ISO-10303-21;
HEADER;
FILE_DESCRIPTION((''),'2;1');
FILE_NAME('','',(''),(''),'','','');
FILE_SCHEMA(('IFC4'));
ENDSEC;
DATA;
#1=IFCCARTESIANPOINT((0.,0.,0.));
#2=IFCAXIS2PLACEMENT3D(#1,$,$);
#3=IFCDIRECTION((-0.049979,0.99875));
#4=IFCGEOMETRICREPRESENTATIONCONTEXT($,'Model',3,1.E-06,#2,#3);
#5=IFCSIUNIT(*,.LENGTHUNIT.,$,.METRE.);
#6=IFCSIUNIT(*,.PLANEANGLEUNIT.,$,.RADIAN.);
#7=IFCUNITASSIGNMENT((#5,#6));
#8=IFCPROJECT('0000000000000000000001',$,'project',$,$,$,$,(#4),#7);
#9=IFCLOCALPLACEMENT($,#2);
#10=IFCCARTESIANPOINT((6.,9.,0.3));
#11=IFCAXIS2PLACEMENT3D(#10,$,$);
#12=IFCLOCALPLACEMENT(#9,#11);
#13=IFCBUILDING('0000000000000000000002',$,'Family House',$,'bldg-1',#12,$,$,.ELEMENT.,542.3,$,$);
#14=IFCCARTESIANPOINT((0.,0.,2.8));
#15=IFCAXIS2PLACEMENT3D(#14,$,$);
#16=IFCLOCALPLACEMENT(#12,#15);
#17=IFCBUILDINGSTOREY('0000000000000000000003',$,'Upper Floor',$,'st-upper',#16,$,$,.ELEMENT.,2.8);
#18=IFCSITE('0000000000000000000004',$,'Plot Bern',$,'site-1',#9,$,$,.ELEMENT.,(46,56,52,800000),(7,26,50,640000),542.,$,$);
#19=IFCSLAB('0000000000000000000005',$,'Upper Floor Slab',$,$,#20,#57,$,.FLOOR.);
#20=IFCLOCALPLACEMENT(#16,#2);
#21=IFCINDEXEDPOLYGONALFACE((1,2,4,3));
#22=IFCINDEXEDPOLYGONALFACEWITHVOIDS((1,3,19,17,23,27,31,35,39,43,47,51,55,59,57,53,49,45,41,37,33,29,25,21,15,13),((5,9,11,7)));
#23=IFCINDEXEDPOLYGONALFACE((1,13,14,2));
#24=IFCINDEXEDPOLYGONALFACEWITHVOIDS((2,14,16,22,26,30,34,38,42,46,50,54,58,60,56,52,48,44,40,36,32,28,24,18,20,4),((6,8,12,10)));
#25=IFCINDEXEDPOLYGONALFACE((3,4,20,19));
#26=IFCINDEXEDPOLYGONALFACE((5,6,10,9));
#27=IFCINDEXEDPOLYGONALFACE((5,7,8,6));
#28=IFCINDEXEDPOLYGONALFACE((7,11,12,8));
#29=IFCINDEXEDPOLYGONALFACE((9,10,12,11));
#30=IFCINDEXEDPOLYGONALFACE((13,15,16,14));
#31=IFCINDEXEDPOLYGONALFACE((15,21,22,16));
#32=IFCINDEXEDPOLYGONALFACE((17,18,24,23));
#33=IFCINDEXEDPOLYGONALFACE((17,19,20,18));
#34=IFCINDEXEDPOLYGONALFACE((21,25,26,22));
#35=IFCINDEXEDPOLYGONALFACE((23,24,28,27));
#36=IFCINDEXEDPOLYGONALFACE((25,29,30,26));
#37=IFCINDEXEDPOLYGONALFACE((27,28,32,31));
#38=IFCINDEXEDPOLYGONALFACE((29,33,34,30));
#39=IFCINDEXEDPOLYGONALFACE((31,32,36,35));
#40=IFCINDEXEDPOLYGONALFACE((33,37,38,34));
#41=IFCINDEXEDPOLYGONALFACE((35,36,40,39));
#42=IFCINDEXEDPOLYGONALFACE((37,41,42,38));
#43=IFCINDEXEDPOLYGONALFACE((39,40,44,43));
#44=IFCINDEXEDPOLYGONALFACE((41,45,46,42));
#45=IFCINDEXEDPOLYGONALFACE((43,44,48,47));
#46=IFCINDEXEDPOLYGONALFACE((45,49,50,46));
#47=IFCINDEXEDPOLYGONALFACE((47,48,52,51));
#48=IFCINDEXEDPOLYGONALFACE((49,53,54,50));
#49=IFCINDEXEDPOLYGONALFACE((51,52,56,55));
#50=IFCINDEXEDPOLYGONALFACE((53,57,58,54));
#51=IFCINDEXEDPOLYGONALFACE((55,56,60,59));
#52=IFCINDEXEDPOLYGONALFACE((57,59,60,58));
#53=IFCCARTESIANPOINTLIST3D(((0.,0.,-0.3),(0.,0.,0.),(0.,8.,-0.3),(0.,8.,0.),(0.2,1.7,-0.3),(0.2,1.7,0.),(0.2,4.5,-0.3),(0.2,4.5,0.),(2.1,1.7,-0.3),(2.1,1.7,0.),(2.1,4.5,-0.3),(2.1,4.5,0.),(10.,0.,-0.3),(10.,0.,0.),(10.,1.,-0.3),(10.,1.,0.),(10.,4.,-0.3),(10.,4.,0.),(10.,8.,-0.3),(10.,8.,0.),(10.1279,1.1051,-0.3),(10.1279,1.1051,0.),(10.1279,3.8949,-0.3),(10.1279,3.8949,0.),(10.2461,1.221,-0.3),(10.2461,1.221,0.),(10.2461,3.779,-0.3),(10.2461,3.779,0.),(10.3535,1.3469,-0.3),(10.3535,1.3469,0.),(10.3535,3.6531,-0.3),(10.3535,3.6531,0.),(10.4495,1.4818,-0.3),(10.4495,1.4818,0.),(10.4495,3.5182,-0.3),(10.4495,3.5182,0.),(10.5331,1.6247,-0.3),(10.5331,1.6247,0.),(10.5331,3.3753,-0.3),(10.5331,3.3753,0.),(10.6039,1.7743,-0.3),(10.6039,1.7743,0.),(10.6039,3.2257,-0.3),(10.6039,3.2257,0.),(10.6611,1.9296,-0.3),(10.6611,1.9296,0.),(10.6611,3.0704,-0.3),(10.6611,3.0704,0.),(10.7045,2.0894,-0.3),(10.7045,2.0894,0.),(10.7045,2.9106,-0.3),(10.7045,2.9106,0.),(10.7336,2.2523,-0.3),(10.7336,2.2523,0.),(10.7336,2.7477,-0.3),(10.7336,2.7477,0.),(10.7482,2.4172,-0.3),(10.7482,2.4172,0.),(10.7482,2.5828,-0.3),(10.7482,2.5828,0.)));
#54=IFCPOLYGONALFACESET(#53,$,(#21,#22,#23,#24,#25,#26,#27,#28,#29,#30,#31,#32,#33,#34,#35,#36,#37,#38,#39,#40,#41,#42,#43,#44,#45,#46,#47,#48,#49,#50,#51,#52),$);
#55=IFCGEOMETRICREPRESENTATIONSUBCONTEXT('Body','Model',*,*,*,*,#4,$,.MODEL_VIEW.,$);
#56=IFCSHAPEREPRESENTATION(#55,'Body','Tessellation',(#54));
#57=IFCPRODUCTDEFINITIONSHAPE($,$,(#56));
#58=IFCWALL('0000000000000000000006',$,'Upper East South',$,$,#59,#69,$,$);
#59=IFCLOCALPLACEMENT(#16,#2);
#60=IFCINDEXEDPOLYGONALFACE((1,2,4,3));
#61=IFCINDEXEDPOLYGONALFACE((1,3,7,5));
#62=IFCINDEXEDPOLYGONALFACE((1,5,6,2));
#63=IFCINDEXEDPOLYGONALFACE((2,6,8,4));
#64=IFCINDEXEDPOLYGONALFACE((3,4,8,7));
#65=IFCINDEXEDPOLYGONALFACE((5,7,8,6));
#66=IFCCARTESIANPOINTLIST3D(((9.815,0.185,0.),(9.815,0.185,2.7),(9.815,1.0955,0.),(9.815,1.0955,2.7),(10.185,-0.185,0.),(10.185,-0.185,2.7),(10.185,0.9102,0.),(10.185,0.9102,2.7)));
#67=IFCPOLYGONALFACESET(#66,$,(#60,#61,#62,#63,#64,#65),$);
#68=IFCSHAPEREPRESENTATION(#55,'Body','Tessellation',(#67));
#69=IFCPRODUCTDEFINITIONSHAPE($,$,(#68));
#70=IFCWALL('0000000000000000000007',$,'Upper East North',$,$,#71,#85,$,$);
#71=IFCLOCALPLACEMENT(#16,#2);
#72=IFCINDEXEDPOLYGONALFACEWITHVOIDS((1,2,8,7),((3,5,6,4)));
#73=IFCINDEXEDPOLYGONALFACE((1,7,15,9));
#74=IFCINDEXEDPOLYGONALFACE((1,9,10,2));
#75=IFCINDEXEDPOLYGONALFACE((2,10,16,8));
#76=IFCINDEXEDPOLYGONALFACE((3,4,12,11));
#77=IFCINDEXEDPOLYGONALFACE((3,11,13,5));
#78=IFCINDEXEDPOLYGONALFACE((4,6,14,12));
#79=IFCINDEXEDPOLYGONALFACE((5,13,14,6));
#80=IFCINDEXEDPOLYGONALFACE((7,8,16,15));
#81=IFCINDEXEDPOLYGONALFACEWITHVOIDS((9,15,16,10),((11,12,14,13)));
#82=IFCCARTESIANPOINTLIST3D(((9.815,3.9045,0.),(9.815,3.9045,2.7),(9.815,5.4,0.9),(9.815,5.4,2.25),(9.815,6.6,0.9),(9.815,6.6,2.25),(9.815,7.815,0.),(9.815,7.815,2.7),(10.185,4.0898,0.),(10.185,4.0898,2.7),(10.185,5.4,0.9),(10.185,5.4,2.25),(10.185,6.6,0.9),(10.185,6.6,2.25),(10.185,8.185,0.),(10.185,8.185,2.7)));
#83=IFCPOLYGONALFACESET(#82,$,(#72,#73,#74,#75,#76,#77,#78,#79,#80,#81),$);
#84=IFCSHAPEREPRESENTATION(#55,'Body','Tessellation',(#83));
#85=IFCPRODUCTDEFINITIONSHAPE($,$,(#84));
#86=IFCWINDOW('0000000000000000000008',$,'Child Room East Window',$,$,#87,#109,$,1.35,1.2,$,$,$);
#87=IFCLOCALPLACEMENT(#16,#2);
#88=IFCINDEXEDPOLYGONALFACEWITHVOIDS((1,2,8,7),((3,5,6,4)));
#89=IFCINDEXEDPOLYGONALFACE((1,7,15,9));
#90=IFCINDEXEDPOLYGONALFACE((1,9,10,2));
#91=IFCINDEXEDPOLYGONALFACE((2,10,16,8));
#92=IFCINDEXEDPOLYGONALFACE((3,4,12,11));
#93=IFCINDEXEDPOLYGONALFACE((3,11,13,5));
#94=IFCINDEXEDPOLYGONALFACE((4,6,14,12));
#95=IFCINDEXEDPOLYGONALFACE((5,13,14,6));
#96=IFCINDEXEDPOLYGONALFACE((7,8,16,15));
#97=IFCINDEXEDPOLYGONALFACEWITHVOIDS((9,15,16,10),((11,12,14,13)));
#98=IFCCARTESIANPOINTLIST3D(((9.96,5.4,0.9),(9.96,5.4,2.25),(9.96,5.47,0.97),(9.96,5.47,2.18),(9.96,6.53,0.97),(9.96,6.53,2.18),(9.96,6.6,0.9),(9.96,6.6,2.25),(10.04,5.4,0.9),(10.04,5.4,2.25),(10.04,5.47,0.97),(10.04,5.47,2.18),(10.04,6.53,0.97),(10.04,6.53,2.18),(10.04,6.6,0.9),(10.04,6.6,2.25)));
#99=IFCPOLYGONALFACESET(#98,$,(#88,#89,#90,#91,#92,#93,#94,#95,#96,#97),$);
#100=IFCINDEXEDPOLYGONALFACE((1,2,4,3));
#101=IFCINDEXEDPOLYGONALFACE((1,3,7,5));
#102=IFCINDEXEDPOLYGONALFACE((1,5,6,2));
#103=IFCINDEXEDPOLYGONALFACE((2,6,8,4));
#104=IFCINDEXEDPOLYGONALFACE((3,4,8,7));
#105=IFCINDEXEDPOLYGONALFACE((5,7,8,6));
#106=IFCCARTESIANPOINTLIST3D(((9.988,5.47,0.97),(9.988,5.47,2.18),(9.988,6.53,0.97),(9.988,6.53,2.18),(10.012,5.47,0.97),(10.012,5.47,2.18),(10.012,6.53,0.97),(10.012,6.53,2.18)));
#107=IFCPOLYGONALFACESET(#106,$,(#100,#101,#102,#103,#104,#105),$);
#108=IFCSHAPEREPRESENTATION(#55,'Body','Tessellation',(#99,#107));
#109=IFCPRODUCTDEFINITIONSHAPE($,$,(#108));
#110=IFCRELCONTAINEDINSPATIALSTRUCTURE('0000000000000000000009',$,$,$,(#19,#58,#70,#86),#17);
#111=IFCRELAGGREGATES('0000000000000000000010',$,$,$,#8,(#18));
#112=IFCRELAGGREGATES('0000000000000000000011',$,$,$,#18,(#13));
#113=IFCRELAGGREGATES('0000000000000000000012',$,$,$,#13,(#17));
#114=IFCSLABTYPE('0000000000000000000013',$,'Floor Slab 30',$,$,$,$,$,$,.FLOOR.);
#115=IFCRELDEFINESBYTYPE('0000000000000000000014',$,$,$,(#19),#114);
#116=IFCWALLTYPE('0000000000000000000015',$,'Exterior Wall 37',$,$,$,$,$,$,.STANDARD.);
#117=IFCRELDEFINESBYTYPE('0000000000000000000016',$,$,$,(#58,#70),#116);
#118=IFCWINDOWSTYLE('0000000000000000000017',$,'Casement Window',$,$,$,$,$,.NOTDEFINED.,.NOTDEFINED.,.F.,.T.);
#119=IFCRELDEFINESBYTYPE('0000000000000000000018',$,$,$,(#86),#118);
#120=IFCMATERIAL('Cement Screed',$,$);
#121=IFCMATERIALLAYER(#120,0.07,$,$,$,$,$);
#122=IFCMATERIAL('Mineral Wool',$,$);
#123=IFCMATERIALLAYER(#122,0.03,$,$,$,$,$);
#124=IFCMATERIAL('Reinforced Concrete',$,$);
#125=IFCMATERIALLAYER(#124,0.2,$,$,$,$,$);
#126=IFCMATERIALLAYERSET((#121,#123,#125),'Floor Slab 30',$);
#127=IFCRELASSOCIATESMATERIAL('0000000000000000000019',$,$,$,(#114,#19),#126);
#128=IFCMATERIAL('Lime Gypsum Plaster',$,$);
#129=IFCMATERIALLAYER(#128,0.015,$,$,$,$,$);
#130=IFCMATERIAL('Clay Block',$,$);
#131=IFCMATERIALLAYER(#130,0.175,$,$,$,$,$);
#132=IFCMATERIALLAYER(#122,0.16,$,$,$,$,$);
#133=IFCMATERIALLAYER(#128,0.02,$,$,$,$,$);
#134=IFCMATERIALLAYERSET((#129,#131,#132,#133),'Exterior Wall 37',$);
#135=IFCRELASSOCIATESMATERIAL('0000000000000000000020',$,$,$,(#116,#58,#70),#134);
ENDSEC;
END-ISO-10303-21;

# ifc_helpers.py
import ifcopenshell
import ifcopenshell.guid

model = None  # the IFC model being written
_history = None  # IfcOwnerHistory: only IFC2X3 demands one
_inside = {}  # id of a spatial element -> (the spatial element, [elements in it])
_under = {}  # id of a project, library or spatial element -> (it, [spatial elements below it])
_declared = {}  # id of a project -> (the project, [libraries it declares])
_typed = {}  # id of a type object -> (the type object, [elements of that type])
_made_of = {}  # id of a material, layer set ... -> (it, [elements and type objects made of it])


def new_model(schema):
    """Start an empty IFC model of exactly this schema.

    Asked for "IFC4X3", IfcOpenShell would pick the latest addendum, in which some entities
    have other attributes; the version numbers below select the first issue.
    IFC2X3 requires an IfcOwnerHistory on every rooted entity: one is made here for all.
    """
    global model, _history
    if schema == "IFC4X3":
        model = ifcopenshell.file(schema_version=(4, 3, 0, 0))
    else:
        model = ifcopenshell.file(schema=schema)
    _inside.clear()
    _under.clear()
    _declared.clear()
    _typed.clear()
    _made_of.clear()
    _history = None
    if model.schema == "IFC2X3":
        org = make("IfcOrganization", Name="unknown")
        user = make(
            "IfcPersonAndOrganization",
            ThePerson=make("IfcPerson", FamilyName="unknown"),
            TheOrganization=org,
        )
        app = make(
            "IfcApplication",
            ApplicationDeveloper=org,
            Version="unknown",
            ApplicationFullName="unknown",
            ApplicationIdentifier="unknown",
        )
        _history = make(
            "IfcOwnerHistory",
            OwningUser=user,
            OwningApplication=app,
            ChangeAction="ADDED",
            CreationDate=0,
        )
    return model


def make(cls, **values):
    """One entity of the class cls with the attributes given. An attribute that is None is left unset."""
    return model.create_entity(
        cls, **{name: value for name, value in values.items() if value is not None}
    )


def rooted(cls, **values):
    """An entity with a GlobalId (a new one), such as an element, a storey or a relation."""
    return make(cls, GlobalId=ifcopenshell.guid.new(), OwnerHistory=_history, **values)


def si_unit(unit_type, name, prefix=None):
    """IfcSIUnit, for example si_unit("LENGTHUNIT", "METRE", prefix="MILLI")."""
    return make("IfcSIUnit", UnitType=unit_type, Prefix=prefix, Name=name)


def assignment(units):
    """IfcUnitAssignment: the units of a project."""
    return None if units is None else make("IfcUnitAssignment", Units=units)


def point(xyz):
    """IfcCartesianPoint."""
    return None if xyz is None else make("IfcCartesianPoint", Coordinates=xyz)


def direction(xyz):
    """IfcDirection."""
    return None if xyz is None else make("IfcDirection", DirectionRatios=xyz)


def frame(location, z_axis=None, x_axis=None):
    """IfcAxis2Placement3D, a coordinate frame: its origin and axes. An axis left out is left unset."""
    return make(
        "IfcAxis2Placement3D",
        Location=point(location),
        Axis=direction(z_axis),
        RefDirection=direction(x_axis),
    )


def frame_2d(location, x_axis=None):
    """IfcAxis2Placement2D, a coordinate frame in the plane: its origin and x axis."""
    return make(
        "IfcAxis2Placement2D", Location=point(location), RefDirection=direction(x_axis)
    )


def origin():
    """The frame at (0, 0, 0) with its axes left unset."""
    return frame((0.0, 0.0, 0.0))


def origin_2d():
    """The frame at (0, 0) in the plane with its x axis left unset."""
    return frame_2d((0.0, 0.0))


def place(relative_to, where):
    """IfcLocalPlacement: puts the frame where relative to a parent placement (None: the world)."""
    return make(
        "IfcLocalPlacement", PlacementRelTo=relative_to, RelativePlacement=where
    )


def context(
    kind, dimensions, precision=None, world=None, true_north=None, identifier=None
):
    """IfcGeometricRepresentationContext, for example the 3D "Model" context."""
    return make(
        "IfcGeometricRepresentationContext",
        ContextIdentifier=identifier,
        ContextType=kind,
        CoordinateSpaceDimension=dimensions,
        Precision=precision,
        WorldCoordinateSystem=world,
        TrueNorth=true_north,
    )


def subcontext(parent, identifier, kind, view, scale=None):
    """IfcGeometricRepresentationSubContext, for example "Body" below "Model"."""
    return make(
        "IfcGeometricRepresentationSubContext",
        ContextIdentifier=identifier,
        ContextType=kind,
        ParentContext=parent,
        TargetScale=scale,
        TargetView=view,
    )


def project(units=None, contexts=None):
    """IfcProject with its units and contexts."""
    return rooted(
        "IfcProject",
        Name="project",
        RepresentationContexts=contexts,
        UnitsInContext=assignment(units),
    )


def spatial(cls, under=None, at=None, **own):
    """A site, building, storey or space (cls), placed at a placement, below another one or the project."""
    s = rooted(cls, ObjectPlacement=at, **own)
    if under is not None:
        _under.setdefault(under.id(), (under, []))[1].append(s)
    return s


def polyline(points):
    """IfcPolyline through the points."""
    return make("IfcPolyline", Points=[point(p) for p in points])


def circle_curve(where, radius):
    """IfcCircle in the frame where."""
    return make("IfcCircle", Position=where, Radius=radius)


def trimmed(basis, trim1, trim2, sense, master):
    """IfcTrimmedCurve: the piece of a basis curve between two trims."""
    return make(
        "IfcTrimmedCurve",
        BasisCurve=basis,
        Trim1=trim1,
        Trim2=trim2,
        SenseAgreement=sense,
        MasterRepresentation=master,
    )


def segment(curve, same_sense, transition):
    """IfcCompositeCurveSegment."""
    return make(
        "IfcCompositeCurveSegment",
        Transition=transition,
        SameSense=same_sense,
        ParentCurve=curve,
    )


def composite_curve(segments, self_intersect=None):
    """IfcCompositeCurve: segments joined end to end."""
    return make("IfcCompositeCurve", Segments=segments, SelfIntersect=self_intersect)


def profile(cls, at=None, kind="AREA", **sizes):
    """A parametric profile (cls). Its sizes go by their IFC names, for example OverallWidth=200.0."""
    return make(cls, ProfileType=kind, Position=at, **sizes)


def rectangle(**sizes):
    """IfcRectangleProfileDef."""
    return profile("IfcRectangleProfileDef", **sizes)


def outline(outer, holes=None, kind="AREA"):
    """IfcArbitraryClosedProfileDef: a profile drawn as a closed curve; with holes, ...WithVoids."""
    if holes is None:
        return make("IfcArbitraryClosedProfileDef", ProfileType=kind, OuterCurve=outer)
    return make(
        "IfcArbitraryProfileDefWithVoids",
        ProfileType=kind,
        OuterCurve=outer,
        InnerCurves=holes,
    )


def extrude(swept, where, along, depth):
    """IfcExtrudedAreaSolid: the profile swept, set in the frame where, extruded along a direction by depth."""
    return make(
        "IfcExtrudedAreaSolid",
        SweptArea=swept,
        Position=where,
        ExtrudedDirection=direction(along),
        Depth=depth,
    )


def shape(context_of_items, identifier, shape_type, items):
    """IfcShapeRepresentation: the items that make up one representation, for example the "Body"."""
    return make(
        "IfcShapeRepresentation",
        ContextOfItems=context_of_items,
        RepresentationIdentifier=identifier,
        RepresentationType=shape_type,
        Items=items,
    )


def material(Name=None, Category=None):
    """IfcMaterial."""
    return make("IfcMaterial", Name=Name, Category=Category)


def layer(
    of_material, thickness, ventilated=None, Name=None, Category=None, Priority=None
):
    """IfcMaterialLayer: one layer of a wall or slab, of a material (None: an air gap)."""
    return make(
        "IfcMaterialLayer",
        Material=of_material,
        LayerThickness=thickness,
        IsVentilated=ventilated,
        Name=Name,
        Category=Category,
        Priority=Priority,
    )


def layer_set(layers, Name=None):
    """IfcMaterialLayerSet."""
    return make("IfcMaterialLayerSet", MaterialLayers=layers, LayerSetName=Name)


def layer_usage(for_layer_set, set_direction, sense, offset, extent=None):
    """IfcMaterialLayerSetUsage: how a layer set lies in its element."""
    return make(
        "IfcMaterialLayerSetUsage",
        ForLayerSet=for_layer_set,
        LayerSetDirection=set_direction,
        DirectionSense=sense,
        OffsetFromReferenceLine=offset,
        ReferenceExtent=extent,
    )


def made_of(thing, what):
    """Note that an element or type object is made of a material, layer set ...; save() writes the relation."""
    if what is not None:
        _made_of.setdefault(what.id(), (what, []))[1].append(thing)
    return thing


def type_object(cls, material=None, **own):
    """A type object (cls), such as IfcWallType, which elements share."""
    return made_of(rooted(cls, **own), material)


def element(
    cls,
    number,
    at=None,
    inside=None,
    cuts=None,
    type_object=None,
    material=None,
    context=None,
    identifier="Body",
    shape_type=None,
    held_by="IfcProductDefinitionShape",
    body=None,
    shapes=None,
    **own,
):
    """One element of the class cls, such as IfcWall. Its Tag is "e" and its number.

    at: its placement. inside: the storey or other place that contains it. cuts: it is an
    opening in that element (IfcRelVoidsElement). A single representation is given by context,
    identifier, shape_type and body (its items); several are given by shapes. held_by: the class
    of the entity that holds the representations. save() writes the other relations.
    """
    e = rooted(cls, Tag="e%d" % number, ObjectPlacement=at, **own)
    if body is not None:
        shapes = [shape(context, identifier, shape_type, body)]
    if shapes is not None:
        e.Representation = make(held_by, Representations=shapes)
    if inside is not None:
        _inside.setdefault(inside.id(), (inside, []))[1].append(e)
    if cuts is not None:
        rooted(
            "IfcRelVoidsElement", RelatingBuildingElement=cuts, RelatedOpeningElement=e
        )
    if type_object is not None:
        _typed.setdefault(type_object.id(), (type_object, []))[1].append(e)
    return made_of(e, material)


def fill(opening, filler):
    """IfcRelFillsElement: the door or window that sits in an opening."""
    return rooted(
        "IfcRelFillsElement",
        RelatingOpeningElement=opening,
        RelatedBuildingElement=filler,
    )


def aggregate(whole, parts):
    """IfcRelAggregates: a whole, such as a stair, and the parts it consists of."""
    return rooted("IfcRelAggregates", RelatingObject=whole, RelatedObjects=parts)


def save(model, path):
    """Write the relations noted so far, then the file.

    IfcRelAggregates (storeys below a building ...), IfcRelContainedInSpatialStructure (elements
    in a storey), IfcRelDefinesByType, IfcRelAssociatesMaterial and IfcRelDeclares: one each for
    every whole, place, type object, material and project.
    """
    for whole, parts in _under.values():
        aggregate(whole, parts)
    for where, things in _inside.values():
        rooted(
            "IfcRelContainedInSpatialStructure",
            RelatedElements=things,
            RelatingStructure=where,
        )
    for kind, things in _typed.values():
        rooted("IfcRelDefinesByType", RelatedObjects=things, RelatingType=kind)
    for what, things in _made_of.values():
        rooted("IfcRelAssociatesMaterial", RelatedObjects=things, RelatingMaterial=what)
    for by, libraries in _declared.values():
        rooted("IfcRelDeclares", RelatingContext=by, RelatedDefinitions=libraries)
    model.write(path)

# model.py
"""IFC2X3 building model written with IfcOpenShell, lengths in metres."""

from ifc_helpers import new_model, si_unit, point, direction, frame, frame_2d, origin, origin_2d, place, context, subcontext, project, spatial, polyline, circle_curve, trimmed, segment, composite_curve, rectangle, outline, extrude, material, layer, layer_set, layer_usage, type_object, element, fill, save


model = new_model("IFC2X3")

# Units and contexts
model_context = context("Model", 3, precision=1e-06, world=origin(), true_north=direction((-0.049979, 0.99875)))
body_context = subcontext(model_context, "Body", "Model", "MODEL_VIEW")
ifc_project = project(units=[si_unit("LENGTHUNIT", "METRE"), si_unit("PLANEANGLEUNIT", "RADIAN")], contexts=[model_context])

# Site, building, storey
site_placement = place(None, origin())
site = spatial("IfcSite", under=ifc_project, at=site_placement, Name="Plot Bern", ObjectType="site-1", CompositionType="ELEMENT", RefLatitude=(46, 56, 52, 800000), RefLongitude=(7, 26, 50, 640000), RefElevation=542.0)
building_placement = place(site_placement, frame((6.0, 9.0, 0.3)))
building = spatial("IfcBuilding", under=site, at=building_placement, Name="Family House", ObjectType="bldg-1", CompositionType="ELEMENT", ElevationOfRefHeight=542.3)
storey_placement = place(building_placement, frame((0.0, 0.0, 2.8)))
storey = spatial("IfcBuildingStorey", under=building, at=storey_placement, Name="Upper Floor", ObjectType="st-upper", CompositionType="ELEMENT", Elevation=2.8)

# Slab
ifc_material_1 = material(Name="Cement Screed")
ifc_layer_1 = layer(ifc_material_1, 0.07)
ifc_material_2 = material(Name="Mineral Wool")
ifc_layer_2 = layer(ifc_material_2, 0.03)
ifc_material_3 = material(Name="Reinforced Concrete")
ifc_layer_3 = layer(ifc_material_3, 0.2)
ifc_layer_set_1 = layer_set([ifc_layer_1, ifc_layer_2, ifc_layer_3], Name="Floor Slab 30")
ifc_layer_usage_1 = layer_usage(ifc_layer_set_1, "AXIS3", "NEGATIVE", 0.3)
slab_type = type_object("IfcSlabType", Name="Floor Slab 30", PredefinedType="FLOOR", material=ifc_layer_set_1)
slab_placement = place(storey_placement, frame((0.0, 0.0, -0.3)))
element("IfcSlab", 1, at=slab_placement, inside=storey, type_object=slab_type, material=ifc_layer_usage_1, Name="Upper Floor Slab", PredefinedType="FLOOR", context=body_context, shape_type="SweptSolid", body=[
    extrude(outline(composite_curve([segment(polyline([(0.0, 0.0), (10.0, 0.0)]), True, "CONTINUOUS"), segment(polyline([(10.0, 0.0), (10.0, 1.0)]), True, "CONTINUOUS"), segment(trimmed(circle_curve(frame_2d((8.875, 2.5)), 1.875), [point((10.0, 1.0))], [point((10.0, 4.0))], True, "CARTESIAN"), True, "CONTINUOUS"), segment(polyline([(10.0, 4.0), (10.0, 8.0)]), True, "CONTINUOUS"), segment(polyline([(10.0, 8.0), (0.0, 8.0)]), True, "CONTINUOUS"), segment(polyline([(0.0, 8.0), (0.0, 0.0)]), True, "CONTINUOUS")], self_intersect=False), holes=[polyline([(0.2, 1.7), (0.2, 4.5), (2.1, 4.5), (2.1, 1.7), (0.2, 1.7)])]), origin(), (0.0, 0.0, 1.0), 0.3),
])

# Shared definitions
ifc_material_4 = material(Name="Lime Gypsum Plaster")
ifc_layer_4 = layer(ifc_material_4, 0.015)
ifc_material_5 = material(Name="Clay Block")
ifc_layer_5 = layer(ifc_material_5, 0.175)
ifc_layer_6 = layer(ifc_material_2, 0.16)
ifc_layer_7 = layer(ifc_material_4, 0.02)
ifc_layer_set_2 = layer_set([ifc_layer_4, ifc_layer_5, ifc_layer_6, ifc_layer_7], Name="Exterior Wall 37")
wall_type_1 = type_object("IfcWallType", Name="Exterior Wall 37", PredefinedType="STANDARD", material=ifc_layer_set_2)

# Wall
ifc_layer_usage_2 = layer_usage(ifc_layer_set_2, "AXIS2", "NEGATIVE", 0.185)
wall_1_placement = place(storey_placement, origin())
element("IfcWall", 2, at=wall_1_placement, inside=storey, type_object=wall_type_1, material=ifc_layer_usage_2, Name="Upper East South", context=body_context, shape_type="SweptSolid", body=[
    extrude(outline(polyline([(10.185, -0.185), (10.185, 0.9102), (9.815, 1.0955), (9.815, 0.185), (10.185, -0.185)])), origin(), (0.0, 0.0, 1.0), 2.7),
])

# Wall, opening, window
ifc_layer_usage_3 = layer_usage(ifc_layer_set_2, "AXIS2", "NEGATIVE", 0.185)
wall_2_placement = place(storey_placement, origin())
wall_2 = element("IfcWall", 3, at=wall_2_placement, inside=storey, type_object=wall_type_1, material=ifc_layer_usage_3, Name="Upper East North", context=body_context, shape_type="SweptSolid", body=[
    extrude(outline(polyline([(10.185, 4.0898), (10.185, 8.185), (9.815, 7.815), (9.815, 3.9045), (10.185, 4.0898)])), origin(), (0.0, 0.0, 1.0), 2.7),
])
opening_1_placement = place(wall_2_placement, frame((10.0, 6.0, 0.9), z_axis=(0.0, 0.0, 1.0), x_axis=(0.0, 1.0, 0.0)))
opening_1 = element("IfcOpeningElement", 4, at=opening_1_placement, cuts=wall_2, context=body_context, shape_type="SweptSolid", body=[
    extrude(rectangle(XDim=1.2, YDim=0.37, at=origin_2d()), origin(), (0.0, 0.0, 1.0), 1.35),
])
window_style_1 = type_object("IfcWindowStyle", Name="Casement Window", ConstructionType="NOTDEFINED", OperationType="NOTDEFINED", ParameterTakesPrecedence=False, Sizeable=True)
window_1_placement = place(opening_1_placement, frame((0.0, 0.0, 0.0), z_axis=(0.0, -1.0, 0.0), x_axis=(1.0, 0.0, 0.0)))
window_1 = element("IfcWindow", 5, at=window_1_placement, inside=storey, type_object=window_style_1, Name="Child Room East Window", OverallHeight=1.35, OverallWidth=1.2, context=body_context, shape_type="SweptSolid", body=[
    extrude(outline(polyline([(-0.6, 0.0), (0.6, 0.0), (0.6, 1.35), (-0.6, 1.35), (-0.6, 0.0)]), holes=[polyline([(-0.53, 0.07), (0.53, 0.07), (0.53, 1.28), (-0.53, 1.28), (-0.53, 0.07)])]), frame((0.0, 0.0, -0.04)), (0.0, 0.0, 1.0), 0.08),
    extrude(rectangle(XDim=1.06, YDim=1.21, at=frame_2d((0.0, 0.675))), frame((0.0, 0.0, -0.012)), (0.0, 0.0, 1.0), 0.024),
])
fill(opening_1, window_1)

save(model, "model.ifc")
